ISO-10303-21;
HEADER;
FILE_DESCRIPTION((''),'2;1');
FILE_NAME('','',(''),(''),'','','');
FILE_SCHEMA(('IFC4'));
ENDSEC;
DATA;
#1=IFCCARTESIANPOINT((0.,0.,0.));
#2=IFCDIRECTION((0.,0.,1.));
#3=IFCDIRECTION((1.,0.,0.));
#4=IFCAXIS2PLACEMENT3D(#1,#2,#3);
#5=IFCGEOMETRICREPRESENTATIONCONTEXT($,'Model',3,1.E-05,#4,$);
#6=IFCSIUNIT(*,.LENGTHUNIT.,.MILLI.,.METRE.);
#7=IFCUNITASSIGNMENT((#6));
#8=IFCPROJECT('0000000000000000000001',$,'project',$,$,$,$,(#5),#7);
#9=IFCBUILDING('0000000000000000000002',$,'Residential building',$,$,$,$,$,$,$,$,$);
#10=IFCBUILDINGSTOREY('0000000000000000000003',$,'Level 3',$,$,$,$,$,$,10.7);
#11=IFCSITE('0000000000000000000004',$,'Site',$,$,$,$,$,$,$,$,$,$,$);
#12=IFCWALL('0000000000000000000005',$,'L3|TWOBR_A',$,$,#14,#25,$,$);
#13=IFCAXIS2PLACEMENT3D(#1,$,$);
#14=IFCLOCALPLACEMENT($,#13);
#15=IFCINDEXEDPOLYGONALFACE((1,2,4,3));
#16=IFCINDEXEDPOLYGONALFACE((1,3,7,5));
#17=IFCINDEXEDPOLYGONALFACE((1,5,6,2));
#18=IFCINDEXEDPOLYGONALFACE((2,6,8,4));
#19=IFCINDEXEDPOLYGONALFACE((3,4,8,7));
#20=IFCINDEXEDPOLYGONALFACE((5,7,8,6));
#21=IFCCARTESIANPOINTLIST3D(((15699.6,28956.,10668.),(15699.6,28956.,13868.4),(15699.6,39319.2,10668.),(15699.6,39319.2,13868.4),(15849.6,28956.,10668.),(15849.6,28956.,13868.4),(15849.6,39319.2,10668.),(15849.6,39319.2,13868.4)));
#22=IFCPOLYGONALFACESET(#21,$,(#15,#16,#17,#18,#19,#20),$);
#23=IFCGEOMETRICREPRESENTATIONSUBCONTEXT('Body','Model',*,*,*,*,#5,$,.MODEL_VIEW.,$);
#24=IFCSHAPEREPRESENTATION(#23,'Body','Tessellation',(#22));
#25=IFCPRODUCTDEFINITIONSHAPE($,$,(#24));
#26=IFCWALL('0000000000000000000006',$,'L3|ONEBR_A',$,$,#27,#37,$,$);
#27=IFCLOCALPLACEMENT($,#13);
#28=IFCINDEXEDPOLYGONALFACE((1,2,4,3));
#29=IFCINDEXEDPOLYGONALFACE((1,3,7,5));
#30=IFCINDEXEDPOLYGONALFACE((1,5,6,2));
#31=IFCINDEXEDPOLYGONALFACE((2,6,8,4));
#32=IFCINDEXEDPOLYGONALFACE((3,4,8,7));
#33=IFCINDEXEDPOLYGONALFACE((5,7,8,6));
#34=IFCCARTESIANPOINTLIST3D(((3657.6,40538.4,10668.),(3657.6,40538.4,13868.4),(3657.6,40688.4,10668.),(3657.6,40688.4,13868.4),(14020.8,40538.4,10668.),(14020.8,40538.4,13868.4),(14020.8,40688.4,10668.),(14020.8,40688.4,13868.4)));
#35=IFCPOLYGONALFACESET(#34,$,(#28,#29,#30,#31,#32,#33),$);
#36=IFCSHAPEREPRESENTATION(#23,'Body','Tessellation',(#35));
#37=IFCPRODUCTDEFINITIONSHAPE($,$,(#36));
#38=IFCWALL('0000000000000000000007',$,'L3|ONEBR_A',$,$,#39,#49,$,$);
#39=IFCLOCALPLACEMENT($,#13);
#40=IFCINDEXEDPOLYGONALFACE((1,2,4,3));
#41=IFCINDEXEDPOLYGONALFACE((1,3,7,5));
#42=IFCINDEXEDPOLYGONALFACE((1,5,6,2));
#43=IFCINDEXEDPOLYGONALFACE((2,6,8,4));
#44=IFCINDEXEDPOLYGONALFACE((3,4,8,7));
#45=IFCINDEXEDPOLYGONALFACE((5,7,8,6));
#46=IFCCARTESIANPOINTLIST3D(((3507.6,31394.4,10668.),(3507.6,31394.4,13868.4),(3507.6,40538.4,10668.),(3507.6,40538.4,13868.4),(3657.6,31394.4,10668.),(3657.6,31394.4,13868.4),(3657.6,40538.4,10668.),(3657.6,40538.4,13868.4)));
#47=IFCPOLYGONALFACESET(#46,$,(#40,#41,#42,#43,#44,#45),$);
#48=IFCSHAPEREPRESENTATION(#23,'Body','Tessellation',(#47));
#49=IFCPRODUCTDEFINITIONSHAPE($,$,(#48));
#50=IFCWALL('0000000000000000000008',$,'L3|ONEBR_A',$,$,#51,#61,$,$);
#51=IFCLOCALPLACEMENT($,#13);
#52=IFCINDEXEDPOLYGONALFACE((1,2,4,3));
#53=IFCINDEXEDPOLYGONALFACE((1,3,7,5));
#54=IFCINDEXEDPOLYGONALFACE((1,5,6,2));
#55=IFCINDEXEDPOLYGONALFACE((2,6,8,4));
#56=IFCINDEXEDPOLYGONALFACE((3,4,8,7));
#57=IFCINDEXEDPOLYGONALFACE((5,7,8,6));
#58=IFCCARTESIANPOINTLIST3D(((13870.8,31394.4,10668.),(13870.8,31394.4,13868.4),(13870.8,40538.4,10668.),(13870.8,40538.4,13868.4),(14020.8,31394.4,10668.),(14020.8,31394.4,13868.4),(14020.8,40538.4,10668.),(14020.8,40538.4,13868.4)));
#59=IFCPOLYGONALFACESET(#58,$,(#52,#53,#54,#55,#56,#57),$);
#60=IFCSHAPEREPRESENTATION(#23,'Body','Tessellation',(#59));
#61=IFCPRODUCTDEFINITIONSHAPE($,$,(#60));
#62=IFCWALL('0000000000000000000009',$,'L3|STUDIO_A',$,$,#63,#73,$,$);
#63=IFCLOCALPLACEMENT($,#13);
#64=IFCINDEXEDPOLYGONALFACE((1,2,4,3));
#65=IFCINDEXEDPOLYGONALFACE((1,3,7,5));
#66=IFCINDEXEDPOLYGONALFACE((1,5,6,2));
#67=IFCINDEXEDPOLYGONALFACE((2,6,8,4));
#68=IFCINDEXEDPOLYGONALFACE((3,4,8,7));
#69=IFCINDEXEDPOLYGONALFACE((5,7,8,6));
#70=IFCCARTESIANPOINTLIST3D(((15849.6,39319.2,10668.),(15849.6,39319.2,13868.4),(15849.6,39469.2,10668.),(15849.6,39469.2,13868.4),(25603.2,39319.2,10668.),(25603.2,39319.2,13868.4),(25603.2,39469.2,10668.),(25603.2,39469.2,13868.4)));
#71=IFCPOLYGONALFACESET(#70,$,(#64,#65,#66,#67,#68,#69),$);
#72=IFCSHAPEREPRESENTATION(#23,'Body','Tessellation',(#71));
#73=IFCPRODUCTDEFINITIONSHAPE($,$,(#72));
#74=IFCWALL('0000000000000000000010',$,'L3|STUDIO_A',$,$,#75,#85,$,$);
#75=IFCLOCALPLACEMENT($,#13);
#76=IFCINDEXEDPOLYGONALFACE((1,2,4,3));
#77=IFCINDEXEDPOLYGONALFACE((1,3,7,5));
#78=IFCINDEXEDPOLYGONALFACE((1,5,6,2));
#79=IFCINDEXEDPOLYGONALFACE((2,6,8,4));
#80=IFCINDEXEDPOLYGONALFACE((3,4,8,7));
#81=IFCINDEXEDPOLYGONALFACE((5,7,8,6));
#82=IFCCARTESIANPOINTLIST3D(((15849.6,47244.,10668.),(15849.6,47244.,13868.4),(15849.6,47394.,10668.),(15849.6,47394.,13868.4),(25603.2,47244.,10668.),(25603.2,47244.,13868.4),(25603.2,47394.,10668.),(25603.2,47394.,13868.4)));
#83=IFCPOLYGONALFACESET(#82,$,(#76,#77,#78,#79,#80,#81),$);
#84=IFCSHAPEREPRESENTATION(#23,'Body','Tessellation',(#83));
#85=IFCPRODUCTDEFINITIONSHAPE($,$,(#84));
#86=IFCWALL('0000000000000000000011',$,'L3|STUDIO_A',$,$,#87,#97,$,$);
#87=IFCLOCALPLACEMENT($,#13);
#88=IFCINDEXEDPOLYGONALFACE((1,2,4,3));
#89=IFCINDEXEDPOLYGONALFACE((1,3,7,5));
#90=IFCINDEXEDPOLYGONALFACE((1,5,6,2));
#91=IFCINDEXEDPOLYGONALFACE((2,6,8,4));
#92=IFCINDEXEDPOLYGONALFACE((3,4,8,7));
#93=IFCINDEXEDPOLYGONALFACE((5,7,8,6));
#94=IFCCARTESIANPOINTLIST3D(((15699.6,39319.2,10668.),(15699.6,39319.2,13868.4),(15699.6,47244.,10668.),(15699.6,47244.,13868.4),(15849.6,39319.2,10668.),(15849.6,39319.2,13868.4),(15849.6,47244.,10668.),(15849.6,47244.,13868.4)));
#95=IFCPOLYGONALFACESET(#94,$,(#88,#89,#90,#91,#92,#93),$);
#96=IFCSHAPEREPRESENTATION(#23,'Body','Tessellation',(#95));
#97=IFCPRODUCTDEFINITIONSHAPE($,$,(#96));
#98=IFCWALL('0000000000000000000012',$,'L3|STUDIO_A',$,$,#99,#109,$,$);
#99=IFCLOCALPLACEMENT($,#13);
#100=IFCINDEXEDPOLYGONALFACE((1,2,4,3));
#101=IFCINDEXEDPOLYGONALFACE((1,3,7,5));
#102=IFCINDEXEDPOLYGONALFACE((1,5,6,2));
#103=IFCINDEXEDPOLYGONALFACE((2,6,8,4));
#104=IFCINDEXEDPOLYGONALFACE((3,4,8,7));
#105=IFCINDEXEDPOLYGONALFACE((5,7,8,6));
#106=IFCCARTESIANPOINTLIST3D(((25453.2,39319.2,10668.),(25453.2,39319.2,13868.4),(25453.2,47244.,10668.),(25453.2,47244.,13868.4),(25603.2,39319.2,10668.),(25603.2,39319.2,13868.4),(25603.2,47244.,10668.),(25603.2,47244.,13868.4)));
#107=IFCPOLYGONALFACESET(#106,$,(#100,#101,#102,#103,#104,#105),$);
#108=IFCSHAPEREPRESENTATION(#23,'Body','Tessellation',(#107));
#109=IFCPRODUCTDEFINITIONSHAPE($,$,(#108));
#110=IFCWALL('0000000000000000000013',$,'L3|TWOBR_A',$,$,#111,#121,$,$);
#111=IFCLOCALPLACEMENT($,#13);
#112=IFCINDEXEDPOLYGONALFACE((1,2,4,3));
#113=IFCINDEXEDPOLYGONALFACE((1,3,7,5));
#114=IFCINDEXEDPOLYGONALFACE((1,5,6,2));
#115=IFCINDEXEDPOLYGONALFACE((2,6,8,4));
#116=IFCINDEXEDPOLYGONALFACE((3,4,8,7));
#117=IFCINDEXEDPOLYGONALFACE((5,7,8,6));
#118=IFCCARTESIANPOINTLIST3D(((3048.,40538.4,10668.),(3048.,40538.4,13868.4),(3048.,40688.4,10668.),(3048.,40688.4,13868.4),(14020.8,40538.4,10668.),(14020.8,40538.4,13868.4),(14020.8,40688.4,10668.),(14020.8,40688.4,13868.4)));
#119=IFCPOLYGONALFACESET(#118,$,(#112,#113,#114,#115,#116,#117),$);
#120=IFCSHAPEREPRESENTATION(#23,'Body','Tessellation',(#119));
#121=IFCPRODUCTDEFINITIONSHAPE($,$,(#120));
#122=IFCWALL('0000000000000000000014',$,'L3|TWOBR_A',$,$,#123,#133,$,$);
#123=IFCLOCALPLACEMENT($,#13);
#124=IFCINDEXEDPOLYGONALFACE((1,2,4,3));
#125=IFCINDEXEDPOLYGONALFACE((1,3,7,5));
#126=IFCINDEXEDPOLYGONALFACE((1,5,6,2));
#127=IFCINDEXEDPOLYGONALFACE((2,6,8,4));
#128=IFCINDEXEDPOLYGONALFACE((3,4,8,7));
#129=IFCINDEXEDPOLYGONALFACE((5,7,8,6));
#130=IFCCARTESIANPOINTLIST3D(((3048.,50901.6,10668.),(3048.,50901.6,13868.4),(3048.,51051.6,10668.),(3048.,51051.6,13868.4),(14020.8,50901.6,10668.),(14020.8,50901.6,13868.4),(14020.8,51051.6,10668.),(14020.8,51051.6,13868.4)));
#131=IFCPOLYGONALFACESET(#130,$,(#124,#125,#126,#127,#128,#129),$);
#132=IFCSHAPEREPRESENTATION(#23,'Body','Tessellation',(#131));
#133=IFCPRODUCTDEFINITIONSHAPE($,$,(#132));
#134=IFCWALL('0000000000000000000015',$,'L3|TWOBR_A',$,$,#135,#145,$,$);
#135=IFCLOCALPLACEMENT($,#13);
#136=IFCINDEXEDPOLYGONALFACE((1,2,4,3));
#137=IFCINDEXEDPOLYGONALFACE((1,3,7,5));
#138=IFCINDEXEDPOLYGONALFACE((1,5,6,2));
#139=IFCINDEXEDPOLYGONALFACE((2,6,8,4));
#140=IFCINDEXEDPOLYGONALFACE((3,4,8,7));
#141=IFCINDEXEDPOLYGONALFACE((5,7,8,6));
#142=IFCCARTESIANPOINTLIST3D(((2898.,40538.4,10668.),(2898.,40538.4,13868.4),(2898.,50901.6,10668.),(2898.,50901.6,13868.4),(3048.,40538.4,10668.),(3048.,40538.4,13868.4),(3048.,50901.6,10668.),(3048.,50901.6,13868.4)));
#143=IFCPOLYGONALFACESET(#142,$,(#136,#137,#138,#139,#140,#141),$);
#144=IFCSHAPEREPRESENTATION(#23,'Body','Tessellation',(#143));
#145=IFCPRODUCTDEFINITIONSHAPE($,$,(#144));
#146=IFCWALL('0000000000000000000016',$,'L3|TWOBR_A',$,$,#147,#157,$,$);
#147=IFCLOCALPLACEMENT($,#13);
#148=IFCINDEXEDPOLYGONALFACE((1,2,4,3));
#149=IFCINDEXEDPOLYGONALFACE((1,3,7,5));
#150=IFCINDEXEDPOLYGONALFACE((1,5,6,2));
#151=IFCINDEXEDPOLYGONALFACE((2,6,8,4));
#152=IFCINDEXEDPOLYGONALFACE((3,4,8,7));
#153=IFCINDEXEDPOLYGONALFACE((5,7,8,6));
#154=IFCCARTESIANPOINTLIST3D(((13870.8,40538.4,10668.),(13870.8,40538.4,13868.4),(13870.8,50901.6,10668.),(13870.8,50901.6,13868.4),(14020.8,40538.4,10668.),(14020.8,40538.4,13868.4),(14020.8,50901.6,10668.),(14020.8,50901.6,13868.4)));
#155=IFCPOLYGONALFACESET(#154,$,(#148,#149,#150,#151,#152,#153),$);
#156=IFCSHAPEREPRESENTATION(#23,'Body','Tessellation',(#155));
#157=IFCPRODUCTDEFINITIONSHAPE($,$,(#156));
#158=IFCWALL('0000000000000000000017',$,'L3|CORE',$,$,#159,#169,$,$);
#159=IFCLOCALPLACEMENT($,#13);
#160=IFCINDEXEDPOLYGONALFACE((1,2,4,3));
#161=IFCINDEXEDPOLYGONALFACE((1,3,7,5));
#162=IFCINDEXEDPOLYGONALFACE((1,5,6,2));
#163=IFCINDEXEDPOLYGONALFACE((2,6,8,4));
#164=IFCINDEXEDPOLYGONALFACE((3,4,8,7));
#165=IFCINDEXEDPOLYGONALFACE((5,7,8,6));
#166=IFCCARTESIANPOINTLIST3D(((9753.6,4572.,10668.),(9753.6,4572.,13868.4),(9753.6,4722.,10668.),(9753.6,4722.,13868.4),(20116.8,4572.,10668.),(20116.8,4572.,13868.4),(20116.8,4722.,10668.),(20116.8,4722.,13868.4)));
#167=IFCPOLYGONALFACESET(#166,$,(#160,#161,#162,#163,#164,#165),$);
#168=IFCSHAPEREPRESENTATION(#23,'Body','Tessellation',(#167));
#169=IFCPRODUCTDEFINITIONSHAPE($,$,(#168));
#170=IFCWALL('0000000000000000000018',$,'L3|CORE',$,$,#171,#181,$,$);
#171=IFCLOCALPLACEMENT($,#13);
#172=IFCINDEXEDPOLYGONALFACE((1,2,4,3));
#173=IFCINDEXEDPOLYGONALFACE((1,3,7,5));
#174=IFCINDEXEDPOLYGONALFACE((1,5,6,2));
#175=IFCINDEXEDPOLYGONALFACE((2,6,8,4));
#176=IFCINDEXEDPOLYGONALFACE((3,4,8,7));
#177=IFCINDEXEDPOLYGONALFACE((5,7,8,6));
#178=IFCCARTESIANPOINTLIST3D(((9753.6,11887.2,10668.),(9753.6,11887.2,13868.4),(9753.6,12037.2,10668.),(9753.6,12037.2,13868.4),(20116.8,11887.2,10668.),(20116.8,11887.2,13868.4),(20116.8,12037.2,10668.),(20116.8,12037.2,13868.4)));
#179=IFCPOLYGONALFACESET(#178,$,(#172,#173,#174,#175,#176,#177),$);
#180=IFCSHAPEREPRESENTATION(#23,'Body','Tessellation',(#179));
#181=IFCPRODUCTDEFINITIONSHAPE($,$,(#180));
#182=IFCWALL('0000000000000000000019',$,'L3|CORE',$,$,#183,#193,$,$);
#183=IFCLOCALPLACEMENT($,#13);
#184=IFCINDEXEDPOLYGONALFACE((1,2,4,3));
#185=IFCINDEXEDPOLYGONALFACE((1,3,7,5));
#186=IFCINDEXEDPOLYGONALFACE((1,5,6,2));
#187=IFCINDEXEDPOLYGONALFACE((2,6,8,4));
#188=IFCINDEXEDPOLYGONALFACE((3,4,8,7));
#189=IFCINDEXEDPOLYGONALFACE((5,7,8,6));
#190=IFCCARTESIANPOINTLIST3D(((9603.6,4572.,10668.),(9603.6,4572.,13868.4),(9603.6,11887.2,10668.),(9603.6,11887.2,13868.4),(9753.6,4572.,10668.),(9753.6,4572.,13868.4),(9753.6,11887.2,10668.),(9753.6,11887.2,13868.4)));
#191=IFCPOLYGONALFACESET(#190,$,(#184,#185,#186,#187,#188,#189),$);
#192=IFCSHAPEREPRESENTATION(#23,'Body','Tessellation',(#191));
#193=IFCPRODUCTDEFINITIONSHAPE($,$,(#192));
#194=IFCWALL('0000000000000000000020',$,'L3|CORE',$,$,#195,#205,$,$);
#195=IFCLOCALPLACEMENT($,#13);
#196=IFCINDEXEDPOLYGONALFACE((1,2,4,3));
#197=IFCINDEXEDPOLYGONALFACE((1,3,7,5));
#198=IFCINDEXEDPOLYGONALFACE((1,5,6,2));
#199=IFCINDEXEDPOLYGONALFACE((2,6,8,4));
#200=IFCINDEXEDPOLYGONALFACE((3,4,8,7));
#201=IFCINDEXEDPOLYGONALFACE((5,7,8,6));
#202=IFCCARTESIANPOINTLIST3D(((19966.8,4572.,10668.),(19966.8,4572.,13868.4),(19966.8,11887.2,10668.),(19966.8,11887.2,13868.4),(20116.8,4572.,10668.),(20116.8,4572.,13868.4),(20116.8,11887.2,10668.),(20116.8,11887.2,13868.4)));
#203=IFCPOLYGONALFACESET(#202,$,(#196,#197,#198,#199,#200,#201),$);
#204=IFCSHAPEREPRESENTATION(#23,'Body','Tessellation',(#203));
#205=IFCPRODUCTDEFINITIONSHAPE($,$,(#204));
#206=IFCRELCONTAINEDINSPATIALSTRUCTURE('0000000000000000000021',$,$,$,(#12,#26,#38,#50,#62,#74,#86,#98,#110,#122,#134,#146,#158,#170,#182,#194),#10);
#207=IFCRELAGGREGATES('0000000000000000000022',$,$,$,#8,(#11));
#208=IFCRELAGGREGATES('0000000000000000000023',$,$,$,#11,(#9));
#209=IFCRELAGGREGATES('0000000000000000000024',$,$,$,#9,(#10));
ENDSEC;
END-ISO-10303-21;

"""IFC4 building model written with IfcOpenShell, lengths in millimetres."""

from ifc_helpers import new_model, si_unit, frame, origin_with_axes, place, context, subcontext, project, spatial, indexed_curve, outline, extrude, element, save


model = new_model("IFC4")

# Units and contexts
model_context = context("Model", 3, precision=1e-05, world=origin_with_axes())
body_context = subcontext(model_context, "Body", "Model", "MODEL_VIEW")
ifc_project = project(units=[si_unit("LENGTHUNIT", "METRE", prefix="MILLI")], contexts=[model_context])

# Site, building, storey
site = spatial("IfcSite", under=ifc_project, Name="Site")
building = spatial("IfcBuilding", under=site, Name="Residential building")
storey = spatial("IfcBuildingStorey", under=building, Name="Level 3", Elevation=10.7)

# Walls
for number, where, z_axis, x_axis, name in (
    (1, (15849.6, 28956.0, 10668.0), (0.0, 0.0, 1.0), (0.0, 1.0, 0.0), "L3|TWOBR_A"),
    (2, (3657.6, 40538.4, 10668.0), (0.0, 0.0, 1.0), (1.0, 0.0, 0.0), "L3|ONEBR_A"),
):
    element("IfcWall", number, at=place(None, frame(where, z_axis=z_axis, x_axis=x_axis)), inside=storey, Name=name, context=body_context, shape_type="SweptSolid", body=[
        extrude(outline(indexed_curve([(0.0, 0.0), (0.0, 150.0), (10363.2, 150.0), (10363.2, 0.0), (0.0, 0.0)], self_intersect=False)), origin_with_axes(), (0.0, 0.0, 1.0), 3200.4),
    ])
for number, where, z_axis, x_axis, name in (
    (3, (3657.6, 31394.4, 10668.0), (0.0, 0.0, 1.0), (0.0, 1.0, 0.0), "L3|ONEBR_A"),
    (4, (14020.8, 31394.4, 10668.0), (0.0, 0.0, 1.0), (0.0, 1.0, 0.0), "L3|ONEBR_A"),
):
    element("IfcWall", number, at=place(None, frame(where, z_axis=z_axis, x_axis=x_axis)), inside=storey, Name=name, context=body_context, shape_type="SweptSolid", body=[
        extrude(outline(indexed_curve([(0.0, 0.0), (0.0, 150.0), (9144.0, 150.0), (9144.0, 0.0), (0.0, 0.0)], self_intersect=False)), origin_with_axes(), (0.0, 0.0, 1.0), 3200.4),
    ])
for number, where, z_axis, x_axis, name in (
    (5, (15849.6, 39319.2, 10668.0), (0.0, 0.0, 1.0), (1.0, 0.0, 0.0), "L3|STUDIO_A"),
    (6, (15849.6, 47244.0, 10668.0), (0.0, 0.0, 1.0), (1.0, 0.0, 0.0), "L3|STUDIO_A"),
):
    element("IfcWall", number, at=place(None, frame(where, z_axis=z_axis, x_axis=x_axis)), inside=storey, Name=name, context=body_context, shape_type="SweptSolid", body=[
        extrude(outline(indexed_curve([(0.0, 0.0), (0.0, 150.0), (9753.6, 150.0), (9753.6, 0.0), (0.0, 0.0)], self_intersect=False)), origin_with_axes(), (0.0, 0.0, 1.0), 3200.4),
    ])
for number, where, z_axis, x_axis, name in (
    (7, (15849.6, 39319.2, 10668.0), (0.0, 0.0, 1.0), (0.0, 1.0, 0.0), "L3|STUDIO_A"),
    (8, (25603.2, 39319.2, 10668.0), (0.0, 0.0, 1.0), (0.0, 1.0, 0.0), "L3|STUDIO_A"),
):
    element("IfcWall", number, at=place(None, frame(where, z_axis=z_axis, x_axis=x_axis)), inside=storey, Name=name, context=body_context, shape_type="SweptSolid", body=[
        extrude(outline(indexed_curve([(0.0, 0.0), (0.0, 150.0), (7924.8, 150.0), (7924.8, 0.0), (0.0, 0.0)], self_intersect=False)), origin_with_axes(), (0.0, 0.0, 1.0), 3200.4),
    ])
for number, where, z_axis, x_axis, name in (
    (9, (3048.0, 40538.4, 10668.0), (0.0, 0.0, 1.0), (1.0, 0.0, 0.0), "L3|TWOBR_A"),
    (10, (3048.0, 50901.6, 10668.0), (0.0, 0.0, 1.0), (1.0, 0.0, 0.0), "L3|TWOBR_A"),
):
    element("IfcWall", number, at=place(None, frame(where, z_axis=z_axis, x_axis=x_axis)), inside=storey, Name=name, context=body_context, shape_type="SweptSolid", body=[
        extrude(outline(indexed_curve([(0.0, 0.0), (0.0, 150.0), (10972.8, 150.0), (10972.8, 0.0), (0.0, 0.0)], self_intersect=False)), origin_with_axes(), (0.0, 0.0, 1.0), 3200.4),
    ])
for number, where, z_axis, x_axis, name in (
    (11, (3048.0, 40538.4, 10668.0), (0.0, 0.0, 1.0), (0.0, 1.0, 0.0), "L3|TWOBR_A"),
    (12, (14020.8, 40538.4, 10668.0), (0.0, 0.0, 1.0), (0.0, 1.0, 0.0), "L3|TWOBR_A"),
    (13, (9753.6, 4572.0, 10668.0), (0.0, 0.0, 1.0), (1.0, 0.0, 0.0), "L3|CORE"),
    (14, (9753.6, 11887.2, 10668.0), (0.0, 0.0, 1.0), (1.0, 0.0, 0.0), "L3|CORE"),
):
    element("IfcWall", number, at=place(None, frame(where, z_axis=z_axis, x_axis=x_axis)), inside=storey, Name=name, context=body_context, shape_type="SweptSolid", body=[
        extrude(outline(indexed_curve([(0.0, 0.0), (0.0, 150.0), (10363.2, 150.0), (10363.2, 0.0), (0.0, 0.0)], self_intersect=False)), origin_with_axes(), (0.0, 0.0, 1.0), 3200.4),
    ])
for number, where, z_axis, x_axis, name in (
    (15, (9753.6, 4572.0, 10668.0), (0.0, 0.0, 1.0), (0.0, 1.0, 0.0), "L3|CORE"),
    (16, (20116.8, 4572.0, 10668.0), (0.0, 0.0, 1.0), (0.0, 1.0, 0.0), "L3|CORE"),
):
    element("IfcWall", number, at=place(None, frame(where, z_axis=z_axis, x_axis=x_axis)), inside=storey, Name=name, context=body_context, shape_type="SweptSolid", body=[
        extrude(outline(indexed_curve([(0.0, 0.0), (0.0, 150.0), (7315.2, 150.0), (7315.2, 0.0), (0.0, 0.0)], self_intersect=False)), origin_with_axes(), (0.0, 0.0, 1.0), 3200.4),
    ])

save(model, "model.ifc")
